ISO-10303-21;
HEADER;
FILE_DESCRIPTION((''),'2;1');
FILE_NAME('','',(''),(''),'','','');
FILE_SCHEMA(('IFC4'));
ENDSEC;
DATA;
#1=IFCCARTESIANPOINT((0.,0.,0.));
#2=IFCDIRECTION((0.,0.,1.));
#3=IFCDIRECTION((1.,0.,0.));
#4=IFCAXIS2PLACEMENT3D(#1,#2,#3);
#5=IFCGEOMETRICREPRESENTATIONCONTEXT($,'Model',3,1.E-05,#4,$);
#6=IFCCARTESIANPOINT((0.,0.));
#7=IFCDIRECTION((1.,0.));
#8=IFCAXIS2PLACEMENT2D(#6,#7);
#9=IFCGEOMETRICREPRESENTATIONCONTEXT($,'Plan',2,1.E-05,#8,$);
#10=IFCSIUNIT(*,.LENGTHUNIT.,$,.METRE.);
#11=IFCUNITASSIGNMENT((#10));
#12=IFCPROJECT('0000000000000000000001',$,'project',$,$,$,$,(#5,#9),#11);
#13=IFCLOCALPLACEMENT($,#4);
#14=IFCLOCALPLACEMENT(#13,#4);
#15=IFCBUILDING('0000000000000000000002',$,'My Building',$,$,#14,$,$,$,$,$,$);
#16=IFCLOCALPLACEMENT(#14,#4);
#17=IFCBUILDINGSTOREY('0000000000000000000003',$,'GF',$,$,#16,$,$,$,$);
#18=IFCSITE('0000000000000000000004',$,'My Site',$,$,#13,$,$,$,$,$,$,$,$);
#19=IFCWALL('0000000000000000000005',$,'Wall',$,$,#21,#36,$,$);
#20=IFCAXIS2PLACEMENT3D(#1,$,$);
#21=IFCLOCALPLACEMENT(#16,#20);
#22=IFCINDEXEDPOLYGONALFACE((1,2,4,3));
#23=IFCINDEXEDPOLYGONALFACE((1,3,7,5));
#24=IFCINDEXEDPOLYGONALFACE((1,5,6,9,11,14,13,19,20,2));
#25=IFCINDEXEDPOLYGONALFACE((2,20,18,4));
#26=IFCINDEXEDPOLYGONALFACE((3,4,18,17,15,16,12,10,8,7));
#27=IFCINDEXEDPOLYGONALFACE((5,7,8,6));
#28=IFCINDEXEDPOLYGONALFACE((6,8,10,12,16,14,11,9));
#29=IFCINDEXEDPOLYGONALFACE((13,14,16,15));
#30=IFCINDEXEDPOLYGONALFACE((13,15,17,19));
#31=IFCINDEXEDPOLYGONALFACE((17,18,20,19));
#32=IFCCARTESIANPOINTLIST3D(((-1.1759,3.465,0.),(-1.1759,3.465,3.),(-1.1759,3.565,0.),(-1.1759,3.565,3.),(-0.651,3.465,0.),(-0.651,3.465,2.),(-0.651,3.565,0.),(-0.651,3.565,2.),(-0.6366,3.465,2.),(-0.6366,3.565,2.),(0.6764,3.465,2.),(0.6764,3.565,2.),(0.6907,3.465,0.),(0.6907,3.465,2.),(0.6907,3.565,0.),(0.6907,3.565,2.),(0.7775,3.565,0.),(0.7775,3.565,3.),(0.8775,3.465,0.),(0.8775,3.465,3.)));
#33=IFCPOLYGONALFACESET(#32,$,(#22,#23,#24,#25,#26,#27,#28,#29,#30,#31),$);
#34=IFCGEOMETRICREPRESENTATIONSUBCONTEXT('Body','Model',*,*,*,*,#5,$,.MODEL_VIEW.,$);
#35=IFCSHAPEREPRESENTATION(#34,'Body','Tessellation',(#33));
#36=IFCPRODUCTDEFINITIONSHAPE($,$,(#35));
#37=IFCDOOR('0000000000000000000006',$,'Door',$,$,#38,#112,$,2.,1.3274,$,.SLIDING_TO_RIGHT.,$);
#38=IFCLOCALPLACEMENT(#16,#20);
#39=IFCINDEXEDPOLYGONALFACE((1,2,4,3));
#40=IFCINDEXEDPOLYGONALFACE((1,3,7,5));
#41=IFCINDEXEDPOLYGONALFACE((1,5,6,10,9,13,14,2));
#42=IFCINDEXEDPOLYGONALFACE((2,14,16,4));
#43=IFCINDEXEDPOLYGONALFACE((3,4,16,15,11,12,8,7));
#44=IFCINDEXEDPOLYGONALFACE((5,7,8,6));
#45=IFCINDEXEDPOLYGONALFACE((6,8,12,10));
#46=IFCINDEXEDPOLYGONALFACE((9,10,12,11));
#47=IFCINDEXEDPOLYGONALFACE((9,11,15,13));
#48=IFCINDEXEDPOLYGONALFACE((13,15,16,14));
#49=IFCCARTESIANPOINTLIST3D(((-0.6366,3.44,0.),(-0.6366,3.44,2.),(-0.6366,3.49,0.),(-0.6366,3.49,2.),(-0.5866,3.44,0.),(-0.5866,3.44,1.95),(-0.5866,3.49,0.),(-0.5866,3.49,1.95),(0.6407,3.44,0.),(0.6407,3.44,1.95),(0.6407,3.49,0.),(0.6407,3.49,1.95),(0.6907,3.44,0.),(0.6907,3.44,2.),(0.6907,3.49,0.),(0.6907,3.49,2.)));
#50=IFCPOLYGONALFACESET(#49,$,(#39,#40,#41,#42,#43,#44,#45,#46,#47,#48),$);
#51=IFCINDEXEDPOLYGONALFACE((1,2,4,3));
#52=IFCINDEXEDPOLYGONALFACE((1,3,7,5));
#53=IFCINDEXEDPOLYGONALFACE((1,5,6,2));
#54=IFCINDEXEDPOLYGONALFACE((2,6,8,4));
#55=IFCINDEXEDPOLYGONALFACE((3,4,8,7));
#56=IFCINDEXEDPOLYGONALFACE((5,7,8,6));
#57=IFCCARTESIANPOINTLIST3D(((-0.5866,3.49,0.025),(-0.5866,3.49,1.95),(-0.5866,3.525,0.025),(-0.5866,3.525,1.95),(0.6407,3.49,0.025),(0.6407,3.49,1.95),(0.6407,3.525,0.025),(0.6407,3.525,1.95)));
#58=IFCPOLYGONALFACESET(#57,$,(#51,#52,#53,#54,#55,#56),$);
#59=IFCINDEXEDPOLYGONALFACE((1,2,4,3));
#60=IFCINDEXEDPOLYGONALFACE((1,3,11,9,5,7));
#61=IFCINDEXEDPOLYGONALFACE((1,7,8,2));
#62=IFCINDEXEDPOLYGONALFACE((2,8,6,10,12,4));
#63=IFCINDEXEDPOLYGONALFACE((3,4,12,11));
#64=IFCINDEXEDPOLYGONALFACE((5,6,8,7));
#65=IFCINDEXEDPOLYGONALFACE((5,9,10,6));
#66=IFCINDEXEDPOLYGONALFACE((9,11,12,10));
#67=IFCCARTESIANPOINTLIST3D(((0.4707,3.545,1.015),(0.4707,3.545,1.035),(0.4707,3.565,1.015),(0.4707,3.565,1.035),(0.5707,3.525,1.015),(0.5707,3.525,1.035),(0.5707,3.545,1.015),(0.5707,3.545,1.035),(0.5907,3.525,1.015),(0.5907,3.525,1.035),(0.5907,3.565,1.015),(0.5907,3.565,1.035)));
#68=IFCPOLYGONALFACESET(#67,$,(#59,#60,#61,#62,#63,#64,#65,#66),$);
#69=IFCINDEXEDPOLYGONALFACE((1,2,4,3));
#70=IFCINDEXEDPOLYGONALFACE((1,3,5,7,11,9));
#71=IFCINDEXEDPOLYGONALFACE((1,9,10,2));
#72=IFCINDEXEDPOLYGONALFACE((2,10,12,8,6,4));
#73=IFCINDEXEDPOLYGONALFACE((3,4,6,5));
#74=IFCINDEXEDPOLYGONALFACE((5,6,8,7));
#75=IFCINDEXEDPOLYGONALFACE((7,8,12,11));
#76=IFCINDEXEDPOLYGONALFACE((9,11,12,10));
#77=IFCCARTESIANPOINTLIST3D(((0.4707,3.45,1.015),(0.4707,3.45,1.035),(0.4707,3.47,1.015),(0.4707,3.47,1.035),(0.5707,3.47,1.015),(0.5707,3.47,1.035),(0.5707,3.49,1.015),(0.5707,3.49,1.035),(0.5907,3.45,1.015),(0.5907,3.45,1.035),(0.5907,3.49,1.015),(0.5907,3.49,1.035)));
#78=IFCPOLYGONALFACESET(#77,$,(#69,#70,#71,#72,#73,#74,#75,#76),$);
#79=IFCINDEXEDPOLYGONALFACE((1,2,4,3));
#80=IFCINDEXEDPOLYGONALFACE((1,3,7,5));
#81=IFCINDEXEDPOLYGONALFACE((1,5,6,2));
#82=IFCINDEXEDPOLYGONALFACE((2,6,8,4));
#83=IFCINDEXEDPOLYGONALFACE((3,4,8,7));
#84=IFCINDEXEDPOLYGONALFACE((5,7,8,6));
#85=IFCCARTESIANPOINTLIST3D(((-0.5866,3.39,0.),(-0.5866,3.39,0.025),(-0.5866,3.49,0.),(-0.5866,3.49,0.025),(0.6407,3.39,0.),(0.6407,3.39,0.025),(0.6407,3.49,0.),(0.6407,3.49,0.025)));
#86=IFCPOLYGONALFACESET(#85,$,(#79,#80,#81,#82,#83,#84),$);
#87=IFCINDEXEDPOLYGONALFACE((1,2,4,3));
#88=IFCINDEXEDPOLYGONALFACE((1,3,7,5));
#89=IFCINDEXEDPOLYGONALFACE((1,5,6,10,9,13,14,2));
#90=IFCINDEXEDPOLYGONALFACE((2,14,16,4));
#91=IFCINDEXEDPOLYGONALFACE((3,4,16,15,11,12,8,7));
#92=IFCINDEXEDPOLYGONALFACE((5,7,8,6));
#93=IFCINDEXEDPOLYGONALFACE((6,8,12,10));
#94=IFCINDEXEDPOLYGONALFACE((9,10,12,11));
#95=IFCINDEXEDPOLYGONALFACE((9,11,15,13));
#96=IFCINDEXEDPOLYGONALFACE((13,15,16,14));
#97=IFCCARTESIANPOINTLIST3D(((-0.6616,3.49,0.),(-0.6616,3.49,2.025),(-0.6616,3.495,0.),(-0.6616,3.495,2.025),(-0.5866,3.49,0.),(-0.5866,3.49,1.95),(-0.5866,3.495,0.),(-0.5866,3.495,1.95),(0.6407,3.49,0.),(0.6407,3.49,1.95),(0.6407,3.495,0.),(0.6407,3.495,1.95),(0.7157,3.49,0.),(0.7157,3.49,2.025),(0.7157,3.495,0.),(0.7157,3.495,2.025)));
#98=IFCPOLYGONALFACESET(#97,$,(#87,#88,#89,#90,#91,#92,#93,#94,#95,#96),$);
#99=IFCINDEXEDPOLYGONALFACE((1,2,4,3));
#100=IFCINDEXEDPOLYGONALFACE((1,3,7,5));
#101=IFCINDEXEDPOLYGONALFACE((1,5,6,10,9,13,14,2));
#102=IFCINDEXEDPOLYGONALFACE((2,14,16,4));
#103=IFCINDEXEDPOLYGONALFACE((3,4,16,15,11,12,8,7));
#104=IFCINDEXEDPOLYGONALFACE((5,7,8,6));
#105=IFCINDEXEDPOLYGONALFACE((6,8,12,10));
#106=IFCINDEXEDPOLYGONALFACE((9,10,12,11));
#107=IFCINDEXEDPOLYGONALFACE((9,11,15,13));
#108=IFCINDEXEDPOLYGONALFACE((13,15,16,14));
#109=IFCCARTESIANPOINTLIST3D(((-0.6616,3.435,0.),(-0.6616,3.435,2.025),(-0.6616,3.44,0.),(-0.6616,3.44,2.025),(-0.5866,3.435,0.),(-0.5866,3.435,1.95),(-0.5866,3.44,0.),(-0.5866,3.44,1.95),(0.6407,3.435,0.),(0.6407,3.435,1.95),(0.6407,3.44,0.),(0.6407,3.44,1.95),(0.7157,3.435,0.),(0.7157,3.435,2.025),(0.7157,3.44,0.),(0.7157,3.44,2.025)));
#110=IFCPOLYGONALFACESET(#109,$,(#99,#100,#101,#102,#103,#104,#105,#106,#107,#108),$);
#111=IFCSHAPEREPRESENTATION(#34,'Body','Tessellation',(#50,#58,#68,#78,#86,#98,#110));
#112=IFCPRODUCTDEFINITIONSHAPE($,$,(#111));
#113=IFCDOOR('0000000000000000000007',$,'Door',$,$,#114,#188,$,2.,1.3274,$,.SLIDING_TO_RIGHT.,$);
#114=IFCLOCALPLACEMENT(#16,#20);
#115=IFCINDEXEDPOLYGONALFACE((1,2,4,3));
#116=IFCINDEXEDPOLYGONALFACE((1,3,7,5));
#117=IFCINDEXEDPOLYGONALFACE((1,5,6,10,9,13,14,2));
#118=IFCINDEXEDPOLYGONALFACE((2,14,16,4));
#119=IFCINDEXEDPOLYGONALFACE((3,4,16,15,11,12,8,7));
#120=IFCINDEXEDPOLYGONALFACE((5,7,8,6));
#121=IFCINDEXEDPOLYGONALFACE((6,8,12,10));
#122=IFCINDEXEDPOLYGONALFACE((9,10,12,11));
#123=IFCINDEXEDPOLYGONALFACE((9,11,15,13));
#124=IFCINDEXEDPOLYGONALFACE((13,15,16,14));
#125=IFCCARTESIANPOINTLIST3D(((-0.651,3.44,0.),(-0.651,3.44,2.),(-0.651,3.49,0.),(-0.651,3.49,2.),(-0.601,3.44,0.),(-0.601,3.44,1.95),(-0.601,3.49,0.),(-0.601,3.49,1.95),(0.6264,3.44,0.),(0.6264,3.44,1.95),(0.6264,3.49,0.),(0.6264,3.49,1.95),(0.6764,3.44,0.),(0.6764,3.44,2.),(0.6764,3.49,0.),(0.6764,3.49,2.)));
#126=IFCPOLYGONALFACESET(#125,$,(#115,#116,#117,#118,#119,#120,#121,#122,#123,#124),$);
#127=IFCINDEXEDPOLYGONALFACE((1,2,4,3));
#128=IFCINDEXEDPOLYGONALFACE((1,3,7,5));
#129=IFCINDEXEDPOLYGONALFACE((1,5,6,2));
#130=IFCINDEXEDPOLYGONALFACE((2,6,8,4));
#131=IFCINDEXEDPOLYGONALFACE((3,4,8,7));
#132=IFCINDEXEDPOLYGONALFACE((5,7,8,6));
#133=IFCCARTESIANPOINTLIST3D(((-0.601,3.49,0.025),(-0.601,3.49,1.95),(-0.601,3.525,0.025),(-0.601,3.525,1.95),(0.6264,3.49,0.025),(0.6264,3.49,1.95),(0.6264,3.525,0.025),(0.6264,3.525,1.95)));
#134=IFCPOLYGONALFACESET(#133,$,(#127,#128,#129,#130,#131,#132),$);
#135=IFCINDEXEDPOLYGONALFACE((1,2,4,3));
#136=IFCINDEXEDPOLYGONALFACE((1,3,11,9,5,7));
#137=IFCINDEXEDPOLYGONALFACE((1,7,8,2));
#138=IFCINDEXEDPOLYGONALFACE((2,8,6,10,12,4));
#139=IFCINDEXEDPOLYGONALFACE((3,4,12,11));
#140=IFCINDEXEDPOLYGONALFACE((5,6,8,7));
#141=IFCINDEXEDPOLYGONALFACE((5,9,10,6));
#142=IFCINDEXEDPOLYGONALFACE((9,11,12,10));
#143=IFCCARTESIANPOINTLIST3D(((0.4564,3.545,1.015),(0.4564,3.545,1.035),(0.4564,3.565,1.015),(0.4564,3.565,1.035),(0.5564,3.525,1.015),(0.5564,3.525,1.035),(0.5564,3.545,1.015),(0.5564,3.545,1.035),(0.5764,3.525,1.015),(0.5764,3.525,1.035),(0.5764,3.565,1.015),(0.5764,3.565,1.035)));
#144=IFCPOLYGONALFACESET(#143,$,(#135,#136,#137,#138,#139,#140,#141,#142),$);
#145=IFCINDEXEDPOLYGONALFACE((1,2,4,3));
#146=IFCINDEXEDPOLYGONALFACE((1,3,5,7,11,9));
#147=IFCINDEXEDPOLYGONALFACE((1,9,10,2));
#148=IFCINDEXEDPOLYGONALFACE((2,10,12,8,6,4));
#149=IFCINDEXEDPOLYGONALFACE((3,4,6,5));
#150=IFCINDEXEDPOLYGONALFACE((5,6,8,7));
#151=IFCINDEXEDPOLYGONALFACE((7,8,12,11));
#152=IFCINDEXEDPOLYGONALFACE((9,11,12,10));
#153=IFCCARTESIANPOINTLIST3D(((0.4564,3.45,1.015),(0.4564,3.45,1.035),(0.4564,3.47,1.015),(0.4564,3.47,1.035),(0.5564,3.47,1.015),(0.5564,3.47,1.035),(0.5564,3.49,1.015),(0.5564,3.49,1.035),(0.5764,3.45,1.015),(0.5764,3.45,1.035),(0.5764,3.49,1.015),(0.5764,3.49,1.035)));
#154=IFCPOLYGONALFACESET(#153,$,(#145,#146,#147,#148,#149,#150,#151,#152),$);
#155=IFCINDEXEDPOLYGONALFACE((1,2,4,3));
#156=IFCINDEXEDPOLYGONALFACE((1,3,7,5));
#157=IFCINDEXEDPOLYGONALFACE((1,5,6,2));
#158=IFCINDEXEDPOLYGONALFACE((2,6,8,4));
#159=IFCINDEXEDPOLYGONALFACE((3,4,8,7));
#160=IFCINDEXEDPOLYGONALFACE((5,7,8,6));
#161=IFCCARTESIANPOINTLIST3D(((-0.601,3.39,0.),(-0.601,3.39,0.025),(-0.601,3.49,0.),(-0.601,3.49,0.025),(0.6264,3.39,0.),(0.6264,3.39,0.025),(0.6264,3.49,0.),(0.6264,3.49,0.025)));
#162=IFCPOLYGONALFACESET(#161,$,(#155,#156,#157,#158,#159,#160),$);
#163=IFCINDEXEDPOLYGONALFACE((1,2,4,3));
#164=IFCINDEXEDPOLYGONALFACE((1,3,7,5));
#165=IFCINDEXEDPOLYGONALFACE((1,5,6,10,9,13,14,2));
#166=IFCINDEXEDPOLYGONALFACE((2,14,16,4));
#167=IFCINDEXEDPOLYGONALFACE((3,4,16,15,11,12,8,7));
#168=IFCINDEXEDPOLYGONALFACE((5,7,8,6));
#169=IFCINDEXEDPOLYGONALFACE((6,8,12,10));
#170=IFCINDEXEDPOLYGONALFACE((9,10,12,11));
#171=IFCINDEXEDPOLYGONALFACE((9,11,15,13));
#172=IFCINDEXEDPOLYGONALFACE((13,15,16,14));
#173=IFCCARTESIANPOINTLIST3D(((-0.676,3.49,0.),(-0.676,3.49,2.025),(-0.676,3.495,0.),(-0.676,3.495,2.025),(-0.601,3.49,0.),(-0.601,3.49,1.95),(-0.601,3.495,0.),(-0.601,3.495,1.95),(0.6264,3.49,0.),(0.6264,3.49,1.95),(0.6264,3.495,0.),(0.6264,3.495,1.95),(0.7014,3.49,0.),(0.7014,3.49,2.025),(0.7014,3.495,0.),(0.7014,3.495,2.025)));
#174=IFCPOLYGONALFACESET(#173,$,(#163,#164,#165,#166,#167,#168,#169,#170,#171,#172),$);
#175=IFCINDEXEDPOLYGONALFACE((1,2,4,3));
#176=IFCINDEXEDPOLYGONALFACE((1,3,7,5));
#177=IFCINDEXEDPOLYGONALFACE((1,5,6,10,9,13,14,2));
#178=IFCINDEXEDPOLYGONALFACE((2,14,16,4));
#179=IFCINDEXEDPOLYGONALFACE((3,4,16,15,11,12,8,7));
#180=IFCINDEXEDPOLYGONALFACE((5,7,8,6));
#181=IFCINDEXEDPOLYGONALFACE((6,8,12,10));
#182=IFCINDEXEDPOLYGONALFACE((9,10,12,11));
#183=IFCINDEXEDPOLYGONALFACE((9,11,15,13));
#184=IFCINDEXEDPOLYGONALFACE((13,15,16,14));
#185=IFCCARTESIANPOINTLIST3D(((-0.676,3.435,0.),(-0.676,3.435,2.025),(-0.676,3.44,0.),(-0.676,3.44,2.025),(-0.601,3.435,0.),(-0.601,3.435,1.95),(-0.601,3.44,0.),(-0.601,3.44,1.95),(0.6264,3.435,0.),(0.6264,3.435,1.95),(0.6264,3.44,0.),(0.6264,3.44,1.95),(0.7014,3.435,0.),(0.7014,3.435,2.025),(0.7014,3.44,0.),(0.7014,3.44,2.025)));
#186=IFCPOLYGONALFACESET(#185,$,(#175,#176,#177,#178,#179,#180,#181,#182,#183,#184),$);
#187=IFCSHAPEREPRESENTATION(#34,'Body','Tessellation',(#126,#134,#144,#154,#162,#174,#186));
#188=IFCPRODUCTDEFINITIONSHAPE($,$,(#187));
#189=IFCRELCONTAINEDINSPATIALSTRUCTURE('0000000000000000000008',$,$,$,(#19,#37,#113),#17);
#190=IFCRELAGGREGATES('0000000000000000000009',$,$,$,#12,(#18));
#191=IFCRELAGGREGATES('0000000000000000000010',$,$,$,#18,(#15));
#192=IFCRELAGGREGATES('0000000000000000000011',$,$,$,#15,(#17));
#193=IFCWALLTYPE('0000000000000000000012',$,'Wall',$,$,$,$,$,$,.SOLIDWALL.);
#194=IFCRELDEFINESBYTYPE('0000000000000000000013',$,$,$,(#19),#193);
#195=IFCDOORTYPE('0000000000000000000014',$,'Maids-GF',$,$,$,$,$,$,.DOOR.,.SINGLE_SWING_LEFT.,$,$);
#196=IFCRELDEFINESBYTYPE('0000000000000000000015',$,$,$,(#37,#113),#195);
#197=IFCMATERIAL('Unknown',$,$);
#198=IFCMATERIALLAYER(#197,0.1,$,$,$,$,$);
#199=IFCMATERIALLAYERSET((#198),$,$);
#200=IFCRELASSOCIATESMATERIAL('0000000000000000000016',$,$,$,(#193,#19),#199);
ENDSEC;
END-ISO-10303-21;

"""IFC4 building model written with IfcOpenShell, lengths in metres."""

from ifc_helpers import new_model, entity, si_unit, frame, origin_with_axes, origin_2d_with_axis, place, context, subcontext, project, spatial, line, indexed_curve, outline, extrude, shape, source, transform, mapped, material, layer, layer_set, layer_usage, type_object, type_shapes, element, fill, save


model = new_model("IFC4")

# Units and contexts
model_context = context("Model", 3, precision=1e-05, world=origin_with_axes())
plan_context = context("Plan", 2, precision=1e-05, world=origin_2d_with_axis())
body_context_1 = subcontext(model_context, "Body", "Model", "MODEL_VIEW")
body_context_2 = subcontext(plan_context, "Body", "Plan", "PLAN_VIEW")
ifc_project = project(units=[si_unit("LENGTHUNIT", "METRE")], contexts=[model_context, plan_context])

# Site, building, storey
site_placement = place(None, origin_with_axes())
site = spatial("IfcSite", under=ifc_project, at=site_placement, Name="My Site")
building_placement = place(site_placement, origin_with_axes())
building = spatial("IfcBuilding", under=site, at=building_placement, Name="My Building")
storey_placement = place(building_placement, origin_with_axes())
storey = spatial("IfcBuildingStorey", under=building, at=storey_placement, Name="GF")

# Shared definitions
ifc_material = material(Name="Unknown")

# Shared definitions
ifc_layer_1 = layer(ifc_material, 0.1)
ifc_layer_set_1 = layer_set([ifc_layer_1])
wall_type = type_object("IfcWallType", Name="Wall", PredefinedType="SOLIDWALL", material=ifc_layer_set_1)

# Wall, openings, doors
ifc_layer_usage_1 = layer_usage(ifc_layer_set_1, "AXIS2", "POSITIVE", 0.0)
wall_1_placement = place(storey_placement, frame((0.7775, 3.565, 0.0), z_axis=(0.0, 0.0, 1.0), x_axis=(-1.0, 0.0, 0.0)))
wall_1 = element("IfcWall", 1, at=wall_1_placement, inside=storey, type_object=wall_type, material=ifc_layer_usage_1, Name="Wall", context=body_context_1, shape_type="SweptSolid", body=[
    extrude(outline(indexed_curve([(0.0, 0.0), (-0.1, 0.1), (1.9534, 0.1), (1.9534, 0.0)], segments=[line(1, 2, 3, 4, 1)])), origin_with_axes(), (0.0, 0.0, 1.0), 3.0),
])
shared_shape_1 = source(origin_with_axes(), body_context_1, "Body", "SweptSolid", [
    extrude(outline(indexed_curve([(0.0, 0.0), (1.3274, 0.0), (1.3274, 2.0), (0.0, 2.0)], segments=[line(1, 2, 3, 4, 1)])), frame((0.0, -0.6, 0.0), z_axis=(0.0, -1.0, 0.0), x_axis=(1.0, 0.0, 0.0)), (0.0, 0.0, -1.0), 1.2),
])
opening_1_placement = place(wall_1_placement, frame((0.0867, 0.075, 0.0), z_axis=(0.0, 0.0, 1.0), x_axis=(1.0, 0.0, 0.0)))
opening_1 = element("IfcOpeningElement", 2, at=opening_1_placement, cuts=wall_1, PredefinedType="OPENING", context=body_context_1, shape_type="MappedRepresentation", body=[
    mapped(shared_shape_1, transform((0.0, 0.0, 0.0), x_axis=(1.0, 0.0, 0.0), y_axis=(0.0, 1.0, 0.0), z_axis=(0.0, 0.0, 1.0), scale=1.0)),
])
opening_2_placement = place(wall_1_placement, frame((0.1011, 0.075, 0.0), z_axis=(0.0, 0.0, 1.0), x_axis=(1.0, 0.0, 0.0)))
opening_2 = element("IfcOpeningElement", 3, at=opening_2_placement, cuts=wall_1, PredefinedType="OPENING", context=body_context_1, shape_type="MappedRepresentation", body=[
    mapped(shared_shape_1, transform((0.0, 0.0, 0.0), x_axis=(1.0, 0.0, 0.0), y_axis=(0.0, 1.0, 0.0), z_axis=(0.0, 0.0, 1.0), scale=1.0)),
])
door_type_1 = type_object("IfcDoorType", Name="Maids-GF", OperationType="SINGLE_SWING_LEFT", PredefinedType="DOOR")
shared_shape_2 = source(origin_with_axes(), body_context_1, "Body", "SweptSolid", [
    extrude(outline(indexed_curve([(0.0, 0.0), (0.0, 2.0), (1.3274, 2.0), (1.3274, 0.0), (1.2774, 0.0), (1.2774, 1.95), (0.05, 1.95), (0.05, 0.0)], segments=[line(1, 2, 3, 4, 5, 6, 7, 8, 1)])), frame((0.0, 0.0, 0.0), z_axis=(0.0, -1.0, 0.0), x_axis=(1.0, 0.0, 0.0)), (0.0, 0.0, -1.0), 0.05),
    extrude(outline(indexed_curve([(0.0, 0.0), (1.2274, 0.0), (1.2274, 0.035), (0.0, 0.035)], segments=[line(1, 2, 3, 4, 1)])), frame((0.05, -0.035, 0.025), z_axis=(0.0, 0.0, 1.0), x_axis=(1.0, 0.0, 0.0)), (0.0, 0.0, 1.0), 1.925),
    extrude(outline(indexed_curve([(0.0, 0.0), (0.0, -0.04), (0.12, -0.04), (0.12, -0.02), (0.02, -0.02), (0.02, 0.0)], segments=[line(1, 2, 3, 4, 5, 6, 1)])), frame((0.1, -0.035, 1.015), z_axis=(0.0, 0.0, 1.0), x_axis=(1.0, 0.0, 0.0)), (0.0, 0.0, 1.0), 0.02),
    extrude(outline(indexed_curve([(0.0, 0.0), (0.0, 0.04), (0.12, 0.04), (0.12, 0.02), (0.02, 0.02), (0.02, 0.0)], segments=[line(1, 2, 3, 4, 5, 6, 1)])), frame((0.1, 0.0, 1.015), z_axis=(0.0, 0.0, 1.0), x_axis=(1.0, 0.0, 0.0)), (0.0, 0.0, 1.0), 0.02),
    extrude(outline(indexed_curve([(0.0, 0.0), (1.2274, 0.0), (1.2274, 0.1), (0.0, 0.1)], segments=[line(1, 2, 3, 4, 1)])), frame((0.05, 0.0, 0.0), z_axis=(0.0, 0.0, 1.0), x_axis=(1.0, 0.0, 0.0)), (0.0, 0.0, 1.0), 0.025),
    extrude(outline(indexed_curve([(0.0, 0.0), (0.0, 2.025), (1.3774, 2.025), (1.3774, 0.0), (1.3024, 0.0), (1.3024, 1.95), (0.075, 1.95), (0.075, 0.0)], segments=[line(1, 2, 3, 4, 5, 6, 7, 8, 1)])), frame((-0.025, -0.005, 0.0), z_axis=(0.0, -1.0, 0.0), x_axis=(1.0, 0.0, 0.0)), (0.0, 0.0, -1.0), 0.005),
    extrude(outline(indexed_curve([(0.0, 0.0), (0.0, 2.025), (1.3774, 2.025), (1.3774, 0.0), (1.3024, 0.0), (1.3024, 1.95), (0.075, 1.95), (0.075, 0.0)], segments=[line(1, 2, 3, 4, 5, 6, 7, 8, 1)])), frame((-0.025, 0.05, 0.0), z_axis=(0.0, -1.0, 0.0), x_axis=(1.0, 0.0, 0.0)), (0.0, 0.0, -1.0), 0.005),
])
shared_shape_3 = source(origin_with_axes(), body_context_2, "Body", "Curve2D", [
    entity("IfcIndexedPolyCurve", entity("IfcCartesianPointList2D", [[0.0, 0.0], [0.05, 0.0], [0.05, 0.05], [0.0, 0.05]]), [entity("IfcLineIndex", [1, 2, 3, 4, 1])]),
    entity("IfcIndexedPolyCurve", entity("IfcCartesianPointList2D", [[1.3274, 0.0], [1.2774, 0.0], [1.2774, 0.05], [1.3274, 0.05]]), [entity("IfcLineIndex", [1, 2, 3, 4, 1])]),
    entity("IfcIndexedPolyCurve", entity("IfcCartesianPointList2D", [[1.891, -0.035], [0.6637, -0.035], [0.6637, 0.0], [1.891, 0.0]]), [entity("IfcLineIndex", [1, 2, 3, 4, 1])]),
])
type_shapes(door_type_1, [shared_shape_2, shared_shape_3])
door_1_placement = place(opening_1_placement, frame((0.0, 0.0, 0.0), z_axis=(0.0, 0.0, 1.0), x_axis=(1.0, 0.0, 0.0)))
door_1 = element("IfcDoor", 4, at=door_1_placement, inside=storey, type_object=door_type_1, Name="Door", OperationType="SLIDING_TO_RIGHT", OverallHeight=2.0, OverallWidth=1.3274, shapes=[
    shape(body_context_1, "Body", "MappedRepresentation", [mapped(shared_shape_2, transform((0.0, 0.0, 0.0), x_axis=(1.0, 0.0, 0.0), y_axis=(0.0, 1.0, 0.0), z_axis=(0.0, 0.0, 1.0), scale=1.0))]),
    shape(body_context_2, "Body", "MappedRepresentation", [mapped(shared_shape_3, transform((0.0, 0.0, 0.0), x_axis=(1.0, 0.0, 0.0), y_axis=(0.0, 1.0, 0.0), z_axis=(0.0, 0.0, 1.0), scale=1.0))]),
])
fill(opening_1, door_1)
door_2_placement = place(opening_2_placement, frame((0.0, 0.0, 0.0), z_axis=(0.0, 0.0, 1.0), x_axis=(1.0, 0.0, 0.0)))
door_2 = element("IfcDoor", 5, at=door_2_placement, inside=storey, type_object=door_type_1, Name="Door", OperationType="SLIDING_TO_RIGHT", OverallHeight=2.0, OverallWidth=1.3274, shapes=[
    shape(body_context_1, "Body", "MappedRepresentation", [mapped(shared_shape_2, transform((0.0, 0.0, 0.0), x_axis=(1.0, 0.0, 0.0), y_axis=(0.0, 1.0, 0.0), z_axis=(0.0, 0.0, 1.0), scale=1.0))]),
    shape(body_context_2, "Body", "MappedRepresentation", [mapped(shared_shape_3, transform((0.0, 0.0, 0.0), x_axis=(1.0, 0.0, 0.0), y_axis=(0.0, 1.0, 0.0), z_axis=(0.0, 0.0, 1.0), scale=1.0))]),
])
fill(opening_2, door_2)

save(model, "model.ifc")
